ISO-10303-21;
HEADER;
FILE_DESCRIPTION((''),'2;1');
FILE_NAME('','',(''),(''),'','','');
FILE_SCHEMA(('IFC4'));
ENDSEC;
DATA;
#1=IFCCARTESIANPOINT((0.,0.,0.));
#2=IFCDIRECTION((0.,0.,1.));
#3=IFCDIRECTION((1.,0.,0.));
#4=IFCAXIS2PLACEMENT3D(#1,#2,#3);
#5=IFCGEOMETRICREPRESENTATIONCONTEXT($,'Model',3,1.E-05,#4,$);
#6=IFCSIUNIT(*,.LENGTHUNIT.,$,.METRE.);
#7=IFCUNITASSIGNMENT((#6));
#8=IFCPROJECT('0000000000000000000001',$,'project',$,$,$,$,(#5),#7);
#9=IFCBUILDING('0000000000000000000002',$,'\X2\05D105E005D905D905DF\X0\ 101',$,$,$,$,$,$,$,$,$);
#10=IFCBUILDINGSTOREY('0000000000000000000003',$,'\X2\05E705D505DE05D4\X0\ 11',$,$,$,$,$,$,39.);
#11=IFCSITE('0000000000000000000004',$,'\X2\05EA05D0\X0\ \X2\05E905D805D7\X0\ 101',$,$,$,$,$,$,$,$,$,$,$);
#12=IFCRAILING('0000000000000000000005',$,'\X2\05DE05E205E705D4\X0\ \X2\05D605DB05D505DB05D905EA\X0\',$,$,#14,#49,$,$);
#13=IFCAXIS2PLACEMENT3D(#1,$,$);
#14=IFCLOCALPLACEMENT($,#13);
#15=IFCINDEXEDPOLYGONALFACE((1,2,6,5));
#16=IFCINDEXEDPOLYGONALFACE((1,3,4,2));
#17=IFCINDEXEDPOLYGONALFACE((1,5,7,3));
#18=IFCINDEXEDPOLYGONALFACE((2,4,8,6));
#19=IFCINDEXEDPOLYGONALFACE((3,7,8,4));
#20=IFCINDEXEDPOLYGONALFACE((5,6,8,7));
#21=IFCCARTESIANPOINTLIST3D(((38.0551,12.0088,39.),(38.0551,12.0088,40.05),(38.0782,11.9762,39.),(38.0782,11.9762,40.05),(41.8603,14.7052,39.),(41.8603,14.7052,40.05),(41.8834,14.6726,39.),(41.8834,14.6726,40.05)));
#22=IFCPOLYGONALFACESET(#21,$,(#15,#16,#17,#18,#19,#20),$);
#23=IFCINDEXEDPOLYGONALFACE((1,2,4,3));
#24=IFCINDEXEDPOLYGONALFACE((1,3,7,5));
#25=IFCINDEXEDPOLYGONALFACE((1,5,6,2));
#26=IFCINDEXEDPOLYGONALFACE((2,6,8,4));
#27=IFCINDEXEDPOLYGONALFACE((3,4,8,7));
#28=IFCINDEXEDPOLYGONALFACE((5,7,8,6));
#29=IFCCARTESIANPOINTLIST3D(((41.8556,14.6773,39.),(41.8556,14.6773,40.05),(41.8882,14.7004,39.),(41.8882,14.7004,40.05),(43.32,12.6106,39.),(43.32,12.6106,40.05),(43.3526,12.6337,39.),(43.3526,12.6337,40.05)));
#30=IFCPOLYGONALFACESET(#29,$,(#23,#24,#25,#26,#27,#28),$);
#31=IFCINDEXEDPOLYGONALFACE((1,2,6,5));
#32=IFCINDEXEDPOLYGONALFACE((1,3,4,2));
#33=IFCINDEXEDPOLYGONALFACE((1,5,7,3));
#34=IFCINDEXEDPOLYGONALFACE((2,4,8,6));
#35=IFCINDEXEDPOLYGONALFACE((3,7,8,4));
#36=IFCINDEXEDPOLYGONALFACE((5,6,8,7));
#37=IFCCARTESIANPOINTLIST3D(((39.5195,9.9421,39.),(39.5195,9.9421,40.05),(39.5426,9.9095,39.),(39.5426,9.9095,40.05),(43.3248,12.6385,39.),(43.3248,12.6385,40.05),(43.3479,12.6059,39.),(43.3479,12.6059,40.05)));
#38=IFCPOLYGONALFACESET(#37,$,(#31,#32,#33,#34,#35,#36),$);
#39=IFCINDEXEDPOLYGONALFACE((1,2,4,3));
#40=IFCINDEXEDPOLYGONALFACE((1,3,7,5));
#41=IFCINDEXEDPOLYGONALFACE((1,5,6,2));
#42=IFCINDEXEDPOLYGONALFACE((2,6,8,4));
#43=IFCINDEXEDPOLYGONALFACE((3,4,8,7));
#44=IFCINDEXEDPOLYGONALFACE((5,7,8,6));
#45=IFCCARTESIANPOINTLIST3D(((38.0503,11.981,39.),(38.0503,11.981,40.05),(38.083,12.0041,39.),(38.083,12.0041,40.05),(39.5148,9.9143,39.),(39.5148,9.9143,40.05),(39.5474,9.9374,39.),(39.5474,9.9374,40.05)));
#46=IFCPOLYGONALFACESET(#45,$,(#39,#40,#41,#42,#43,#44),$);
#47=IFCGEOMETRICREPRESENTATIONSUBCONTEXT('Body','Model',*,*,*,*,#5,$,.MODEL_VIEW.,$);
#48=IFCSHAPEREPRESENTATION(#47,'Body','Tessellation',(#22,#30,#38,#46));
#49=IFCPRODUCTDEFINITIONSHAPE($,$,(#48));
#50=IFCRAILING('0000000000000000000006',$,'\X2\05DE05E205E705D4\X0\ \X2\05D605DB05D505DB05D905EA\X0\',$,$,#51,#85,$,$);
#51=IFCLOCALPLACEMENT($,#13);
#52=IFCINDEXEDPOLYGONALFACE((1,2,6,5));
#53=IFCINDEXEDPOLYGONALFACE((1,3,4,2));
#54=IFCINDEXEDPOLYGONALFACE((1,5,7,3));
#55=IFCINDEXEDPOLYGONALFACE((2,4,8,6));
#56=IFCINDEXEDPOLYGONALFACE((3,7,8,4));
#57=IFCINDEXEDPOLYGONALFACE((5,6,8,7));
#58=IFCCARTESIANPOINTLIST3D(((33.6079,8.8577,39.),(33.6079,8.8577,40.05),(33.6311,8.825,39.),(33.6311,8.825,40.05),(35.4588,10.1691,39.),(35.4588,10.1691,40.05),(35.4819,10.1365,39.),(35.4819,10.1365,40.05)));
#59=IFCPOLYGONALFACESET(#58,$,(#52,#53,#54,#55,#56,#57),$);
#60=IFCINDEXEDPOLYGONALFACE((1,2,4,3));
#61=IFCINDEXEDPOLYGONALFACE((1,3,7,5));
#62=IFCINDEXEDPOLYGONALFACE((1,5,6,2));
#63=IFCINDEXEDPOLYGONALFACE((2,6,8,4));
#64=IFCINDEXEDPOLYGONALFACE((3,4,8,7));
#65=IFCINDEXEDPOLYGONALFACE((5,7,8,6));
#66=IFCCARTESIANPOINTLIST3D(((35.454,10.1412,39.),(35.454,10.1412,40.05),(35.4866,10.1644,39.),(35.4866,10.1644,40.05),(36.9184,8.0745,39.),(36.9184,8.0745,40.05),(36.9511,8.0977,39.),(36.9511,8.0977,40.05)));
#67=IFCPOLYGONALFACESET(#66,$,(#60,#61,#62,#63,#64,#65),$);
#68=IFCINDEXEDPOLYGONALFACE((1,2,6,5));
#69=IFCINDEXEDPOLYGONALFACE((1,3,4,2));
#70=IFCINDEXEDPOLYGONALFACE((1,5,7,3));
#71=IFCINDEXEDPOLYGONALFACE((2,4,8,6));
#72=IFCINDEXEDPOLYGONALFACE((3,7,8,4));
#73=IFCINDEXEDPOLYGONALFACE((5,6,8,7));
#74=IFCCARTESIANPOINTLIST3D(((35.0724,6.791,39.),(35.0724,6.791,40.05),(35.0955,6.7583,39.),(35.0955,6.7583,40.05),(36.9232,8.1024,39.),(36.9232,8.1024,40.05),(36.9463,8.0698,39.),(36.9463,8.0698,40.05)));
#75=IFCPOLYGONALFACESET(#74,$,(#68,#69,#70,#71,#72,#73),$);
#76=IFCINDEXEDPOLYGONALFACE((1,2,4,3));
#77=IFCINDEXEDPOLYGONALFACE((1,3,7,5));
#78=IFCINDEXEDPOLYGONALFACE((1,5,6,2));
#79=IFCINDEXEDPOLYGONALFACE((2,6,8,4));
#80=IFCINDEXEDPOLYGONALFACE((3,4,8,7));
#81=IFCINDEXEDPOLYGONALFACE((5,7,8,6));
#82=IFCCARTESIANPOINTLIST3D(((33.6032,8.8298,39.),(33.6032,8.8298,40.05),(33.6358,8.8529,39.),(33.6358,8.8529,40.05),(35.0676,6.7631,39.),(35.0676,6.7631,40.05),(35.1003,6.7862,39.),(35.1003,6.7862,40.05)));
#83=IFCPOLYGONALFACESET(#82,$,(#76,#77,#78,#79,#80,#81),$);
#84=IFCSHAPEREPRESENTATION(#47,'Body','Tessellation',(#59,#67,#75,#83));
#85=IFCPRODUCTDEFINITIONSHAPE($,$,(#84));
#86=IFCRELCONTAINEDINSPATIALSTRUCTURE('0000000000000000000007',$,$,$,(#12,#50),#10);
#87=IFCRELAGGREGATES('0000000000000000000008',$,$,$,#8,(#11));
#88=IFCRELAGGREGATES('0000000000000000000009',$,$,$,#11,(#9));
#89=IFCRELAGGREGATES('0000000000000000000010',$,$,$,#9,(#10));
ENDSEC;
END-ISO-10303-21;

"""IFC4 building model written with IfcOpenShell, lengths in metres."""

from ifc_helpers import new_model, si_unit, frame, origin_with_axes, context, subcontext, project, spatial, polyline, outline, extrude, element, save


model = new_model("IFC4")

# Units and contexts
model_context = context("Model", 3, precision=1e-05, world=origin_with_axes())
body_context = subcontext(model_context, "Body", "Model", "MODEL_VIEW")
ifc_project = project(units=[si_unit("LENGTHUNIT", "METRE")], contexts=[model_context])

# Site, building, storey
site = spatial("IfcSite", under=ifc_project, Name="תא שטח 101")
building = spatial("IfcBuilding", under=site, Name="בניין 101")
storey = spatial("IfcBuildingStorey", under=building, Name="קומה 11", Elevation=39.0)

# Railings
element("IfcRailing", 1, inside=storey, Name="מעקה זכוכית", context=body_context, shape_type="SweptSolid", body=[
    extrude(outline(polyline([(38.0782, 11.9762), (41.8834, 14.6726), (41.8603, 14.7052), (38.0551, 12.0088), (38.0782, 11.9762)])), frame((0.0, 0.0, 39.0)), (0.0, 0.0, 1.0), 1.05),
    extrude(outline(polyline([(41.8556, 14.6773), (43.32, 12.6106), (43.3526, 12.6337), (41.8882, 14.7004), (41.8556, 14.6773)])), frame((0.0, 0.0, 39.0)), (0.0, 0.0, 1.0), 1.05),
    extrude(outline(polyline([(43.3248, 12.6385), (39.5195, 9.9421), (39.5426, 9.9095), (43.3479, 12.6059), (43.3248, 12.6385)])), frame((0.0, 0.0, 39.0)), (0.0, 0.0, 1.0), 1.05),
    extrude(outline(polyline([(39.5474, 9.9374), (38.083, 12.0041), (38.0503, 11.981), (39.5148, 9.9143), (39.5474, 9.9374)])), frame((0.0, 0.0, 39.0)), (0.0, 0.0, 1.0), 1.05),
])
element("IfcRailing", 2, inside=storey, Name="מעקה זכוכית", context=body_context, shape_type="SweptSolid", body=[
    extrude(outline(polyline([(33.6311, 8.825), (35.4819, 10.1365), (35.4588, 10.1691), (33.6079, 8.8577), (33.6311, 8.825)])), frame((0.0, 0.0, 39.0)), (0.0, 0.0, 1.0), 1.05),
    extrude(outline(polyline([(35.454, 10.1412), (36.9184, 8.0745), (36.9511, 8.0977), (35.4866, 10.1644), (35.454, 10.1412)])), frame((0.0, 0.0, 39.0)), (0.0, 0.0, 1.0), 1.05),
    extrude(outline(polyline([(36.9232, 8.1024), (35.0724, 6.791), (35.0955, 6.7583), (36.9463, 8.0698), (36.9232, 8.1024)])), frame((0.0, 0.0, 39.0)), (0.0, 0.0, 1.0), 1.05),
    extrude(outline(polyline([(35.1003, 6.7862), (33.6358, 8.8529), (33.6032, 8.8298), (35.0676, 6.7631), (35.1003, 6.7862)])), frame((0.0, 0.0, 39.0)), (0.0, 0.0, 1.0), 1.05),
])

save(model, "model.ifc")
